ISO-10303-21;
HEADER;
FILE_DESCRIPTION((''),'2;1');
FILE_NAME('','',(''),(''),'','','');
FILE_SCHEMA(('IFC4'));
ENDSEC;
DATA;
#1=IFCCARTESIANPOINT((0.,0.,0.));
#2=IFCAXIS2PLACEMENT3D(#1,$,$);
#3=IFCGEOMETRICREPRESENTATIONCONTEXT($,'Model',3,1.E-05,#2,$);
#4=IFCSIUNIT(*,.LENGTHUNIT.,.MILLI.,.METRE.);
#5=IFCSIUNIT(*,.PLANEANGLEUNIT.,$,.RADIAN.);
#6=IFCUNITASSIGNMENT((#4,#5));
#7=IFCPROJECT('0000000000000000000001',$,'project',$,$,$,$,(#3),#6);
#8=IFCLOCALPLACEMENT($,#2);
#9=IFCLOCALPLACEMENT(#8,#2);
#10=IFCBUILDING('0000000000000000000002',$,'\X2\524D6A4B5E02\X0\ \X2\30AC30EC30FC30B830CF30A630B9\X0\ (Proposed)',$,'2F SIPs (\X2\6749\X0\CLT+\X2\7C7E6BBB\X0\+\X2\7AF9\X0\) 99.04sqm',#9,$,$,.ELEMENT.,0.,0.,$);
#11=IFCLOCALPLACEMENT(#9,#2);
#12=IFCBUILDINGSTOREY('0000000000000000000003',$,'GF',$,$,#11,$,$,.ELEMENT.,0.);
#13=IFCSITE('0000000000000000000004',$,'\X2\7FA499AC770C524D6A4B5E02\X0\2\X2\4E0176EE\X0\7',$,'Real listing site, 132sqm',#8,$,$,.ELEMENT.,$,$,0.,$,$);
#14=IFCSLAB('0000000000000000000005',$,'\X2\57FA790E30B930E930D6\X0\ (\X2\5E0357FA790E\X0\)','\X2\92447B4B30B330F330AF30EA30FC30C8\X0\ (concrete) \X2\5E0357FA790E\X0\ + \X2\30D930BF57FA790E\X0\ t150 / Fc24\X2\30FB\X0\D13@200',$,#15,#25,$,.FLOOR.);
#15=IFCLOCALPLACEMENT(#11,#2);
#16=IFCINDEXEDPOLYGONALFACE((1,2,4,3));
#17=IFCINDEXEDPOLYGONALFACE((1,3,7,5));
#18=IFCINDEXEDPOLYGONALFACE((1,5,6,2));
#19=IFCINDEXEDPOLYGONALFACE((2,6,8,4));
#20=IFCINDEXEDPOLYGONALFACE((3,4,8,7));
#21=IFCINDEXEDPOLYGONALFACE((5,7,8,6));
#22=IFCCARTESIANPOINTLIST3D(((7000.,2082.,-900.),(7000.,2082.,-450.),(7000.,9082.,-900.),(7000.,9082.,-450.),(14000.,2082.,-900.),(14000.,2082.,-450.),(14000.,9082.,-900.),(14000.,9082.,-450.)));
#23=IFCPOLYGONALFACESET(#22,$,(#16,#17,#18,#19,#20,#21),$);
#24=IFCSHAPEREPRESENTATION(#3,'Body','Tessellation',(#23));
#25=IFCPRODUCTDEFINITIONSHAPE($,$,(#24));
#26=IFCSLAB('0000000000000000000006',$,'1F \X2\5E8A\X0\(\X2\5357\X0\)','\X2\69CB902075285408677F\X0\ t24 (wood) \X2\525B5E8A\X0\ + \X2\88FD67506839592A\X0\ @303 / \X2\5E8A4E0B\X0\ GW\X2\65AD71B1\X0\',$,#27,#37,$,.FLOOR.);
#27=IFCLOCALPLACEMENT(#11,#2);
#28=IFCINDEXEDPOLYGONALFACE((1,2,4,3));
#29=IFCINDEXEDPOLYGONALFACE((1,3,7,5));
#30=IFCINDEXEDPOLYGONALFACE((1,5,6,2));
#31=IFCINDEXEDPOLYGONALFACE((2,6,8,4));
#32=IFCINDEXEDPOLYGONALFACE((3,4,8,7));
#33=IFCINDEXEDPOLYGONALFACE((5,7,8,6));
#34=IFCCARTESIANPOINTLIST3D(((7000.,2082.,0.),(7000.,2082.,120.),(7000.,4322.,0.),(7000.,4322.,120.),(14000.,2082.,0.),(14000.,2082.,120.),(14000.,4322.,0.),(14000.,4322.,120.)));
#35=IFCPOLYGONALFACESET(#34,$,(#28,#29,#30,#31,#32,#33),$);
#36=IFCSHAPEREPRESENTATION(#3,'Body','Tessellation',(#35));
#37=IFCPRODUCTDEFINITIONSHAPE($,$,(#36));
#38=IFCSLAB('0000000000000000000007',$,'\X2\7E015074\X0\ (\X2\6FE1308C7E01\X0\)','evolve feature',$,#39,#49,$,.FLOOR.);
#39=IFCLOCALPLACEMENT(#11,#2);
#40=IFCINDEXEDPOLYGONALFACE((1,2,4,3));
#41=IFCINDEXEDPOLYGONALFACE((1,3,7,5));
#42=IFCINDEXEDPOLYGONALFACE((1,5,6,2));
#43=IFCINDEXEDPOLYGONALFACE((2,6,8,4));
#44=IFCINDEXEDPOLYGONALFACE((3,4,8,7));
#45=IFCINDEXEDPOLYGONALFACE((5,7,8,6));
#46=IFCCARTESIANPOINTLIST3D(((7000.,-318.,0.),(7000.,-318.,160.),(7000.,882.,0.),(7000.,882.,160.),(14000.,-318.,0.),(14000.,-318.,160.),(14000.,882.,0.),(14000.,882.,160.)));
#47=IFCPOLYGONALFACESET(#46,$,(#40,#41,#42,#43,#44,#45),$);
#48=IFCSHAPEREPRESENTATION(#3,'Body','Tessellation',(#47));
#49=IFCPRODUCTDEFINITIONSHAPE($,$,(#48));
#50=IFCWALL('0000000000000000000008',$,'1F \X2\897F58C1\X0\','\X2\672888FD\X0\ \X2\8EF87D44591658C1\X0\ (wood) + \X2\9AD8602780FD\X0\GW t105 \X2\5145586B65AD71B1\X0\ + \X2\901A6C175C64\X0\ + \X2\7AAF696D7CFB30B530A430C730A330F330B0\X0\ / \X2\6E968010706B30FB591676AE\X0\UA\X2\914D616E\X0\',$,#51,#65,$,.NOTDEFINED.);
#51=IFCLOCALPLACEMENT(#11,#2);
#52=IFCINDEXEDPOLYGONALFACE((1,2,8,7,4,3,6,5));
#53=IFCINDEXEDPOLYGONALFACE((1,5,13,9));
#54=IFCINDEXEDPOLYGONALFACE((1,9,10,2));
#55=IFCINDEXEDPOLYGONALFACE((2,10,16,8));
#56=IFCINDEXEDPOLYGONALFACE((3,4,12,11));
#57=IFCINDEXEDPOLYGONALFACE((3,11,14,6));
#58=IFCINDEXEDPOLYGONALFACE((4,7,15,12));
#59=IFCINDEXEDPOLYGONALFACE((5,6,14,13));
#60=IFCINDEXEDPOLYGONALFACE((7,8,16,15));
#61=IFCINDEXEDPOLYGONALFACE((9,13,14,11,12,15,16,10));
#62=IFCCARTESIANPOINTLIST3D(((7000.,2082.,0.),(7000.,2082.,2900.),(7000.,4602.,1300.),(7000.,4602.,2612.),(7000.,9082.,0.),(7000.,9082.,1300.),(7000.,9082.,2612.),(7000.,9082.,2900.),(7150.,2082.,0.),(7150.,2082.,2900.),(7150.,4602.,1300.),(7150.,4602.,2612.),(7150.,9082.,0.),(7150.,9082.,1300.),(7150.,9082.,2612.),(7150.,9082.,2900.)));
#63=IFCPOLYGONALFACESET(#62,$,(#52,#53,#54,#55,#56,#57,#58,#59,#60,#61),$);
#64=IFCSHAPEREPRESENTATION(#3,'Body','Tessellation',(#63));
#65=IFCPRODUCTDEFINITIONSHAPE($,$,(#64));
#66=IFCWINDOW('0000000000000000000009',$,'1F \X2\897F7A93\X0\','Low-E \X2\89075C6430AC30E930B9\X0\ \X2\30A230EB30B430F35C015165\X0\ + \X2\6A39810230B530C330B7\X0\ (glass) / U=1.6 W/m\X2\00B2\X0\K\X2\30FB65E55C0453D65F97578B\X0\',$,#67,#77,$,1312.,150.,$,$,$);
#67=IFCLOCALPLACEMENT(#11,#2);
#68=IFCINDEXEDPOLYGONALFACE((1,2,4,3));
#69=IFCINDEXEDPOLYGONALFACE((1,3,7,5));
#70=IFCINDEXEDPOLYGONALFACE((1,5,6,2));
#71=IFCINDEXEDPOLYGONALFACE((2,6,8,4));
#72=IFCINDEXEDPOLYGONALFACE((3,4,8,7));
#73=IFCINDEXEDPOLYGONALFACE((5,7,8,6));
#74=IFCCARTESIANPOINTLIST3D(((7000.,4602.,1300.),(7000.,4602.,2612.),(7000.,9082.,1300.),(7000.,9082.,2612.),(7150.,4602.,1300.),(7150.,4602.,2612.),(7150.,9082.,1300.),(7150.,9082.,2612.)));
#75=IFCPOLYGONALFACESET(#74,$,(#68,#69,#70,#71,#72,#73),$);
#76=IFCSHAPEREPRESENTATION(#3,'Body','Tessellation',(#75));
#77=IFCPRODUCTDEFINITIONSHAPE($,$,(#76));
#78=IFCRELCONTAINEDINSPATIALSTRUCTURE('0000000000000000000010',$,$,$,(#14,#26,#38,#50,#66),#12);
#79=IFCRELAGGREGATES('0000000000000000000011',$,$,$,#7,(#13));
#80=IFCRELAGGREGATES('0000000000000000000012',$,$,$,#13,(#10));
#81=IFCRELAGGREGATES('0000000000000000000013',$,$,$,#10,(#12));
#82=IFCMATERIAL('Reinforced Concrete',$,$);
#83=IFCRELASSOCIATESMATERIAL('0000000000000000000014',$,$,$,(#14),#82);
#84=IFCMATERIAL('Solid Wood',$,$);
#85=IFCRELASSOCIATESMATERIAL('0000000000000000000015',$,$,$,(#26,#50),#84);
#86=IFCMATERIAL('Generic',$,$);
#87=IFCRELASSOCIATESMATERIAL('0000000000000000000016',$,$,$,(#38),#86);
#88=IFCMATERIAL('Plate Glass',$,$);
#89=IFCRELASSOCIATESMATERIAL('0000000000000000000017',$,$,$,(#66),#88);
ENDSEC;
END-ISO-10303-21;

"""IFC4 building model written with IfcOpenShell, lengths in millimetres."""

from ifc_helpers import new_model, si_unit, frame, frame_2d, origin, place, context, project, spatial, rectangle, extrude, material, element, fill, save


model = new_model("IFC4")

# Units and contexts
model_context = context("Model", 3, precision=1e-05, world=origin())
ifc_project = project(units=[si_unit("LENGTHUNIT", "METRE", prefix="MILLI"), si_unit("PLANEANGLEUNIT", "RADIAN")], contexts=[model_context])

# Site, building, storey
site_placement = place(None, origin())
site = spatial("IfcSite", under=ifc_project, at=site_placement, Name="群馬県前橋市2丁目7", ObjectType="Real listing site, 132sqm", CompositionType="ELEMENT", RefElevation=0.0)
building_placement = place(site_placement, origin())
building = spatial("IfcBuilding", under=site, at=building_placement, Name="前橋市 ガレージハウス (Proposed)", ObjectType="2F SIPs (杉CLT+籾殻+竹) 99.04sqm", CompositionType="ELEMENT", ElevationOfRefHeight=0.0, ElevationOfTerrain=0.0)
storey_placement = place(building_placement, origin())
storey = spatial("IfcBuildingStorey", under=building, at=storey_placement, Name="GF", CompositionType="ELEMENT", Elevation=0.0)

# Slabs
ifc_material_1 = material(Name="Reinforced Concrete")
slab_1_placement = place(storey_placement, frame((3500.0, 1041.0, -450.0)))
element("IfcSlab", 1, at=slab_1_placement, inside=storey, material=ifc_material_1, Name="基礎スラブ (布基礎)", Description="鉄筋コンクリート (concrete) 布基礎 + ベタ基礎 t150 / Fc24・D13@200", PredefinedType="FLOOR", context=model_context, shape_type="SweptSolid", body=[
    extrude(rectangle(XDim=7000.0, YDim=7000.0, at=frame_2d((3500.0, 3500.0))), frame((3500.0, 1041.0, -450.0)), (0.0, 0.0, 1.0), 450.0),
])
ifc_material_2 = material(Name="Solid Wood")
slab_2_placement = place(storey_placement, frame((3500.0, 1041.0, 0.0)))
element("IfcSlab", 2, at=slab_2_placement, inside=storey, material=ifc_material_2, Name="1F 床(南)", Description="構造用合板 t24 (wood) 剛床 + 製材根太 @303 / 床下 GW断熱", PredefinedType="FLOOR", context=model_context, shape_type="SweptSolid", body=[
    extrude(rectangle(XDim=7000.0, YDim=2240.0, at=frame_2d((3500.0, 1120.0))), frame((3500.0, 1041.0, 0.0)), (0.0, 0.0, 1.0), 120.0),
])
ifc_material_3 = material(Name="Generic")
slab_3_placement = place(storey_placement, frame((3500.0, -159.0, 0.0)))
element("IfcSlab", 3, at=slab_3_placement, inside=storey, material=ifc_material_3, Name="縁側 (濡れ縁)", Description="evolve feature", PredefinedType="FLOOR", context=model_context, shape_type="SweptSolid", body=[
    extrude(rectangle(XDim=7000.0, YDim=1200.0, at=frame_2d((3500.0, 600.0))), frame((3500.0, -159.0, 0.0)), (0.0, 0.0, 1.0), 160.0),
])

# Shared definitions
ifc_material_4 = material(Name="Plate Glass")

# Wall, opening, window
wall_1_placement = place(storey_placement, frame((3500.0, 1041.0, 0.0)))
wall_1 = element("IfcWall", 4, at=wall_1_placement, inside=storey, material=ifc_material_2, Name="1F 西壁", Description="木製 軸組外壁 (wood) + 高性能GW t105 充填断熱 + 通気層 + 窯業系サイディング / 準耐火・外皮UA配慮", PredefinedType="NOTDEFINED", context=model_context, shape_type="SweptSolid", body=[
    extrude(rectangle(XDim=150.0, YDim=7000.0, at=frame_2d((75.0, 3500.0))), frame((3500.0, 1041.0, 0.0)), (0.0, 0.0, 1.0), 2900.0),
])
opening_1_placement = place(storey_placement, frame((3500.0, 2301.0, 650.0)))
opening_1 = element("IfcOpeningElement", 5, at=opening_1_placement, cuts=wall_1, PredefinedType="NOTDEFINED", context=model_context, shape_type="SweptSolid", body=[
    extrude(rectangle(XDim=150.0, YDim=4480.0, at=frame_2d((75.0, 2240.0))), frame((3500.0, 2301.0, 650.0)), (0.0, 0.0, 1.0), 1312.0),
])
window_1_placement = place(storey_placement, frame((3500.0, 2301.0, 650.0)))
window_1 = element("IfcWindow", 6, at=window_1_placement, inside=storey, material=ifc_material_4, Name="1F 西窓", Description="Low-E 複層ガラス アルゴン封入 + 樹脂サッシ (glass) / U=1.6 W/m²K・日射取得型", OverallHeight=1312.0, OverallWidth=150.0, context=model_context, shape_type="SweptSolid", body=[
    extrude(rectangle(XDim=150.0, YDim=4480.0, at=frame_2d((75.0, 2240.0))), frame((3500.0, 2301.0, 650.0)), (0.0, 0.0, 1.0), 1312.0),
])
fill(opening_1, window_1)

save(model, "model.ifc")
